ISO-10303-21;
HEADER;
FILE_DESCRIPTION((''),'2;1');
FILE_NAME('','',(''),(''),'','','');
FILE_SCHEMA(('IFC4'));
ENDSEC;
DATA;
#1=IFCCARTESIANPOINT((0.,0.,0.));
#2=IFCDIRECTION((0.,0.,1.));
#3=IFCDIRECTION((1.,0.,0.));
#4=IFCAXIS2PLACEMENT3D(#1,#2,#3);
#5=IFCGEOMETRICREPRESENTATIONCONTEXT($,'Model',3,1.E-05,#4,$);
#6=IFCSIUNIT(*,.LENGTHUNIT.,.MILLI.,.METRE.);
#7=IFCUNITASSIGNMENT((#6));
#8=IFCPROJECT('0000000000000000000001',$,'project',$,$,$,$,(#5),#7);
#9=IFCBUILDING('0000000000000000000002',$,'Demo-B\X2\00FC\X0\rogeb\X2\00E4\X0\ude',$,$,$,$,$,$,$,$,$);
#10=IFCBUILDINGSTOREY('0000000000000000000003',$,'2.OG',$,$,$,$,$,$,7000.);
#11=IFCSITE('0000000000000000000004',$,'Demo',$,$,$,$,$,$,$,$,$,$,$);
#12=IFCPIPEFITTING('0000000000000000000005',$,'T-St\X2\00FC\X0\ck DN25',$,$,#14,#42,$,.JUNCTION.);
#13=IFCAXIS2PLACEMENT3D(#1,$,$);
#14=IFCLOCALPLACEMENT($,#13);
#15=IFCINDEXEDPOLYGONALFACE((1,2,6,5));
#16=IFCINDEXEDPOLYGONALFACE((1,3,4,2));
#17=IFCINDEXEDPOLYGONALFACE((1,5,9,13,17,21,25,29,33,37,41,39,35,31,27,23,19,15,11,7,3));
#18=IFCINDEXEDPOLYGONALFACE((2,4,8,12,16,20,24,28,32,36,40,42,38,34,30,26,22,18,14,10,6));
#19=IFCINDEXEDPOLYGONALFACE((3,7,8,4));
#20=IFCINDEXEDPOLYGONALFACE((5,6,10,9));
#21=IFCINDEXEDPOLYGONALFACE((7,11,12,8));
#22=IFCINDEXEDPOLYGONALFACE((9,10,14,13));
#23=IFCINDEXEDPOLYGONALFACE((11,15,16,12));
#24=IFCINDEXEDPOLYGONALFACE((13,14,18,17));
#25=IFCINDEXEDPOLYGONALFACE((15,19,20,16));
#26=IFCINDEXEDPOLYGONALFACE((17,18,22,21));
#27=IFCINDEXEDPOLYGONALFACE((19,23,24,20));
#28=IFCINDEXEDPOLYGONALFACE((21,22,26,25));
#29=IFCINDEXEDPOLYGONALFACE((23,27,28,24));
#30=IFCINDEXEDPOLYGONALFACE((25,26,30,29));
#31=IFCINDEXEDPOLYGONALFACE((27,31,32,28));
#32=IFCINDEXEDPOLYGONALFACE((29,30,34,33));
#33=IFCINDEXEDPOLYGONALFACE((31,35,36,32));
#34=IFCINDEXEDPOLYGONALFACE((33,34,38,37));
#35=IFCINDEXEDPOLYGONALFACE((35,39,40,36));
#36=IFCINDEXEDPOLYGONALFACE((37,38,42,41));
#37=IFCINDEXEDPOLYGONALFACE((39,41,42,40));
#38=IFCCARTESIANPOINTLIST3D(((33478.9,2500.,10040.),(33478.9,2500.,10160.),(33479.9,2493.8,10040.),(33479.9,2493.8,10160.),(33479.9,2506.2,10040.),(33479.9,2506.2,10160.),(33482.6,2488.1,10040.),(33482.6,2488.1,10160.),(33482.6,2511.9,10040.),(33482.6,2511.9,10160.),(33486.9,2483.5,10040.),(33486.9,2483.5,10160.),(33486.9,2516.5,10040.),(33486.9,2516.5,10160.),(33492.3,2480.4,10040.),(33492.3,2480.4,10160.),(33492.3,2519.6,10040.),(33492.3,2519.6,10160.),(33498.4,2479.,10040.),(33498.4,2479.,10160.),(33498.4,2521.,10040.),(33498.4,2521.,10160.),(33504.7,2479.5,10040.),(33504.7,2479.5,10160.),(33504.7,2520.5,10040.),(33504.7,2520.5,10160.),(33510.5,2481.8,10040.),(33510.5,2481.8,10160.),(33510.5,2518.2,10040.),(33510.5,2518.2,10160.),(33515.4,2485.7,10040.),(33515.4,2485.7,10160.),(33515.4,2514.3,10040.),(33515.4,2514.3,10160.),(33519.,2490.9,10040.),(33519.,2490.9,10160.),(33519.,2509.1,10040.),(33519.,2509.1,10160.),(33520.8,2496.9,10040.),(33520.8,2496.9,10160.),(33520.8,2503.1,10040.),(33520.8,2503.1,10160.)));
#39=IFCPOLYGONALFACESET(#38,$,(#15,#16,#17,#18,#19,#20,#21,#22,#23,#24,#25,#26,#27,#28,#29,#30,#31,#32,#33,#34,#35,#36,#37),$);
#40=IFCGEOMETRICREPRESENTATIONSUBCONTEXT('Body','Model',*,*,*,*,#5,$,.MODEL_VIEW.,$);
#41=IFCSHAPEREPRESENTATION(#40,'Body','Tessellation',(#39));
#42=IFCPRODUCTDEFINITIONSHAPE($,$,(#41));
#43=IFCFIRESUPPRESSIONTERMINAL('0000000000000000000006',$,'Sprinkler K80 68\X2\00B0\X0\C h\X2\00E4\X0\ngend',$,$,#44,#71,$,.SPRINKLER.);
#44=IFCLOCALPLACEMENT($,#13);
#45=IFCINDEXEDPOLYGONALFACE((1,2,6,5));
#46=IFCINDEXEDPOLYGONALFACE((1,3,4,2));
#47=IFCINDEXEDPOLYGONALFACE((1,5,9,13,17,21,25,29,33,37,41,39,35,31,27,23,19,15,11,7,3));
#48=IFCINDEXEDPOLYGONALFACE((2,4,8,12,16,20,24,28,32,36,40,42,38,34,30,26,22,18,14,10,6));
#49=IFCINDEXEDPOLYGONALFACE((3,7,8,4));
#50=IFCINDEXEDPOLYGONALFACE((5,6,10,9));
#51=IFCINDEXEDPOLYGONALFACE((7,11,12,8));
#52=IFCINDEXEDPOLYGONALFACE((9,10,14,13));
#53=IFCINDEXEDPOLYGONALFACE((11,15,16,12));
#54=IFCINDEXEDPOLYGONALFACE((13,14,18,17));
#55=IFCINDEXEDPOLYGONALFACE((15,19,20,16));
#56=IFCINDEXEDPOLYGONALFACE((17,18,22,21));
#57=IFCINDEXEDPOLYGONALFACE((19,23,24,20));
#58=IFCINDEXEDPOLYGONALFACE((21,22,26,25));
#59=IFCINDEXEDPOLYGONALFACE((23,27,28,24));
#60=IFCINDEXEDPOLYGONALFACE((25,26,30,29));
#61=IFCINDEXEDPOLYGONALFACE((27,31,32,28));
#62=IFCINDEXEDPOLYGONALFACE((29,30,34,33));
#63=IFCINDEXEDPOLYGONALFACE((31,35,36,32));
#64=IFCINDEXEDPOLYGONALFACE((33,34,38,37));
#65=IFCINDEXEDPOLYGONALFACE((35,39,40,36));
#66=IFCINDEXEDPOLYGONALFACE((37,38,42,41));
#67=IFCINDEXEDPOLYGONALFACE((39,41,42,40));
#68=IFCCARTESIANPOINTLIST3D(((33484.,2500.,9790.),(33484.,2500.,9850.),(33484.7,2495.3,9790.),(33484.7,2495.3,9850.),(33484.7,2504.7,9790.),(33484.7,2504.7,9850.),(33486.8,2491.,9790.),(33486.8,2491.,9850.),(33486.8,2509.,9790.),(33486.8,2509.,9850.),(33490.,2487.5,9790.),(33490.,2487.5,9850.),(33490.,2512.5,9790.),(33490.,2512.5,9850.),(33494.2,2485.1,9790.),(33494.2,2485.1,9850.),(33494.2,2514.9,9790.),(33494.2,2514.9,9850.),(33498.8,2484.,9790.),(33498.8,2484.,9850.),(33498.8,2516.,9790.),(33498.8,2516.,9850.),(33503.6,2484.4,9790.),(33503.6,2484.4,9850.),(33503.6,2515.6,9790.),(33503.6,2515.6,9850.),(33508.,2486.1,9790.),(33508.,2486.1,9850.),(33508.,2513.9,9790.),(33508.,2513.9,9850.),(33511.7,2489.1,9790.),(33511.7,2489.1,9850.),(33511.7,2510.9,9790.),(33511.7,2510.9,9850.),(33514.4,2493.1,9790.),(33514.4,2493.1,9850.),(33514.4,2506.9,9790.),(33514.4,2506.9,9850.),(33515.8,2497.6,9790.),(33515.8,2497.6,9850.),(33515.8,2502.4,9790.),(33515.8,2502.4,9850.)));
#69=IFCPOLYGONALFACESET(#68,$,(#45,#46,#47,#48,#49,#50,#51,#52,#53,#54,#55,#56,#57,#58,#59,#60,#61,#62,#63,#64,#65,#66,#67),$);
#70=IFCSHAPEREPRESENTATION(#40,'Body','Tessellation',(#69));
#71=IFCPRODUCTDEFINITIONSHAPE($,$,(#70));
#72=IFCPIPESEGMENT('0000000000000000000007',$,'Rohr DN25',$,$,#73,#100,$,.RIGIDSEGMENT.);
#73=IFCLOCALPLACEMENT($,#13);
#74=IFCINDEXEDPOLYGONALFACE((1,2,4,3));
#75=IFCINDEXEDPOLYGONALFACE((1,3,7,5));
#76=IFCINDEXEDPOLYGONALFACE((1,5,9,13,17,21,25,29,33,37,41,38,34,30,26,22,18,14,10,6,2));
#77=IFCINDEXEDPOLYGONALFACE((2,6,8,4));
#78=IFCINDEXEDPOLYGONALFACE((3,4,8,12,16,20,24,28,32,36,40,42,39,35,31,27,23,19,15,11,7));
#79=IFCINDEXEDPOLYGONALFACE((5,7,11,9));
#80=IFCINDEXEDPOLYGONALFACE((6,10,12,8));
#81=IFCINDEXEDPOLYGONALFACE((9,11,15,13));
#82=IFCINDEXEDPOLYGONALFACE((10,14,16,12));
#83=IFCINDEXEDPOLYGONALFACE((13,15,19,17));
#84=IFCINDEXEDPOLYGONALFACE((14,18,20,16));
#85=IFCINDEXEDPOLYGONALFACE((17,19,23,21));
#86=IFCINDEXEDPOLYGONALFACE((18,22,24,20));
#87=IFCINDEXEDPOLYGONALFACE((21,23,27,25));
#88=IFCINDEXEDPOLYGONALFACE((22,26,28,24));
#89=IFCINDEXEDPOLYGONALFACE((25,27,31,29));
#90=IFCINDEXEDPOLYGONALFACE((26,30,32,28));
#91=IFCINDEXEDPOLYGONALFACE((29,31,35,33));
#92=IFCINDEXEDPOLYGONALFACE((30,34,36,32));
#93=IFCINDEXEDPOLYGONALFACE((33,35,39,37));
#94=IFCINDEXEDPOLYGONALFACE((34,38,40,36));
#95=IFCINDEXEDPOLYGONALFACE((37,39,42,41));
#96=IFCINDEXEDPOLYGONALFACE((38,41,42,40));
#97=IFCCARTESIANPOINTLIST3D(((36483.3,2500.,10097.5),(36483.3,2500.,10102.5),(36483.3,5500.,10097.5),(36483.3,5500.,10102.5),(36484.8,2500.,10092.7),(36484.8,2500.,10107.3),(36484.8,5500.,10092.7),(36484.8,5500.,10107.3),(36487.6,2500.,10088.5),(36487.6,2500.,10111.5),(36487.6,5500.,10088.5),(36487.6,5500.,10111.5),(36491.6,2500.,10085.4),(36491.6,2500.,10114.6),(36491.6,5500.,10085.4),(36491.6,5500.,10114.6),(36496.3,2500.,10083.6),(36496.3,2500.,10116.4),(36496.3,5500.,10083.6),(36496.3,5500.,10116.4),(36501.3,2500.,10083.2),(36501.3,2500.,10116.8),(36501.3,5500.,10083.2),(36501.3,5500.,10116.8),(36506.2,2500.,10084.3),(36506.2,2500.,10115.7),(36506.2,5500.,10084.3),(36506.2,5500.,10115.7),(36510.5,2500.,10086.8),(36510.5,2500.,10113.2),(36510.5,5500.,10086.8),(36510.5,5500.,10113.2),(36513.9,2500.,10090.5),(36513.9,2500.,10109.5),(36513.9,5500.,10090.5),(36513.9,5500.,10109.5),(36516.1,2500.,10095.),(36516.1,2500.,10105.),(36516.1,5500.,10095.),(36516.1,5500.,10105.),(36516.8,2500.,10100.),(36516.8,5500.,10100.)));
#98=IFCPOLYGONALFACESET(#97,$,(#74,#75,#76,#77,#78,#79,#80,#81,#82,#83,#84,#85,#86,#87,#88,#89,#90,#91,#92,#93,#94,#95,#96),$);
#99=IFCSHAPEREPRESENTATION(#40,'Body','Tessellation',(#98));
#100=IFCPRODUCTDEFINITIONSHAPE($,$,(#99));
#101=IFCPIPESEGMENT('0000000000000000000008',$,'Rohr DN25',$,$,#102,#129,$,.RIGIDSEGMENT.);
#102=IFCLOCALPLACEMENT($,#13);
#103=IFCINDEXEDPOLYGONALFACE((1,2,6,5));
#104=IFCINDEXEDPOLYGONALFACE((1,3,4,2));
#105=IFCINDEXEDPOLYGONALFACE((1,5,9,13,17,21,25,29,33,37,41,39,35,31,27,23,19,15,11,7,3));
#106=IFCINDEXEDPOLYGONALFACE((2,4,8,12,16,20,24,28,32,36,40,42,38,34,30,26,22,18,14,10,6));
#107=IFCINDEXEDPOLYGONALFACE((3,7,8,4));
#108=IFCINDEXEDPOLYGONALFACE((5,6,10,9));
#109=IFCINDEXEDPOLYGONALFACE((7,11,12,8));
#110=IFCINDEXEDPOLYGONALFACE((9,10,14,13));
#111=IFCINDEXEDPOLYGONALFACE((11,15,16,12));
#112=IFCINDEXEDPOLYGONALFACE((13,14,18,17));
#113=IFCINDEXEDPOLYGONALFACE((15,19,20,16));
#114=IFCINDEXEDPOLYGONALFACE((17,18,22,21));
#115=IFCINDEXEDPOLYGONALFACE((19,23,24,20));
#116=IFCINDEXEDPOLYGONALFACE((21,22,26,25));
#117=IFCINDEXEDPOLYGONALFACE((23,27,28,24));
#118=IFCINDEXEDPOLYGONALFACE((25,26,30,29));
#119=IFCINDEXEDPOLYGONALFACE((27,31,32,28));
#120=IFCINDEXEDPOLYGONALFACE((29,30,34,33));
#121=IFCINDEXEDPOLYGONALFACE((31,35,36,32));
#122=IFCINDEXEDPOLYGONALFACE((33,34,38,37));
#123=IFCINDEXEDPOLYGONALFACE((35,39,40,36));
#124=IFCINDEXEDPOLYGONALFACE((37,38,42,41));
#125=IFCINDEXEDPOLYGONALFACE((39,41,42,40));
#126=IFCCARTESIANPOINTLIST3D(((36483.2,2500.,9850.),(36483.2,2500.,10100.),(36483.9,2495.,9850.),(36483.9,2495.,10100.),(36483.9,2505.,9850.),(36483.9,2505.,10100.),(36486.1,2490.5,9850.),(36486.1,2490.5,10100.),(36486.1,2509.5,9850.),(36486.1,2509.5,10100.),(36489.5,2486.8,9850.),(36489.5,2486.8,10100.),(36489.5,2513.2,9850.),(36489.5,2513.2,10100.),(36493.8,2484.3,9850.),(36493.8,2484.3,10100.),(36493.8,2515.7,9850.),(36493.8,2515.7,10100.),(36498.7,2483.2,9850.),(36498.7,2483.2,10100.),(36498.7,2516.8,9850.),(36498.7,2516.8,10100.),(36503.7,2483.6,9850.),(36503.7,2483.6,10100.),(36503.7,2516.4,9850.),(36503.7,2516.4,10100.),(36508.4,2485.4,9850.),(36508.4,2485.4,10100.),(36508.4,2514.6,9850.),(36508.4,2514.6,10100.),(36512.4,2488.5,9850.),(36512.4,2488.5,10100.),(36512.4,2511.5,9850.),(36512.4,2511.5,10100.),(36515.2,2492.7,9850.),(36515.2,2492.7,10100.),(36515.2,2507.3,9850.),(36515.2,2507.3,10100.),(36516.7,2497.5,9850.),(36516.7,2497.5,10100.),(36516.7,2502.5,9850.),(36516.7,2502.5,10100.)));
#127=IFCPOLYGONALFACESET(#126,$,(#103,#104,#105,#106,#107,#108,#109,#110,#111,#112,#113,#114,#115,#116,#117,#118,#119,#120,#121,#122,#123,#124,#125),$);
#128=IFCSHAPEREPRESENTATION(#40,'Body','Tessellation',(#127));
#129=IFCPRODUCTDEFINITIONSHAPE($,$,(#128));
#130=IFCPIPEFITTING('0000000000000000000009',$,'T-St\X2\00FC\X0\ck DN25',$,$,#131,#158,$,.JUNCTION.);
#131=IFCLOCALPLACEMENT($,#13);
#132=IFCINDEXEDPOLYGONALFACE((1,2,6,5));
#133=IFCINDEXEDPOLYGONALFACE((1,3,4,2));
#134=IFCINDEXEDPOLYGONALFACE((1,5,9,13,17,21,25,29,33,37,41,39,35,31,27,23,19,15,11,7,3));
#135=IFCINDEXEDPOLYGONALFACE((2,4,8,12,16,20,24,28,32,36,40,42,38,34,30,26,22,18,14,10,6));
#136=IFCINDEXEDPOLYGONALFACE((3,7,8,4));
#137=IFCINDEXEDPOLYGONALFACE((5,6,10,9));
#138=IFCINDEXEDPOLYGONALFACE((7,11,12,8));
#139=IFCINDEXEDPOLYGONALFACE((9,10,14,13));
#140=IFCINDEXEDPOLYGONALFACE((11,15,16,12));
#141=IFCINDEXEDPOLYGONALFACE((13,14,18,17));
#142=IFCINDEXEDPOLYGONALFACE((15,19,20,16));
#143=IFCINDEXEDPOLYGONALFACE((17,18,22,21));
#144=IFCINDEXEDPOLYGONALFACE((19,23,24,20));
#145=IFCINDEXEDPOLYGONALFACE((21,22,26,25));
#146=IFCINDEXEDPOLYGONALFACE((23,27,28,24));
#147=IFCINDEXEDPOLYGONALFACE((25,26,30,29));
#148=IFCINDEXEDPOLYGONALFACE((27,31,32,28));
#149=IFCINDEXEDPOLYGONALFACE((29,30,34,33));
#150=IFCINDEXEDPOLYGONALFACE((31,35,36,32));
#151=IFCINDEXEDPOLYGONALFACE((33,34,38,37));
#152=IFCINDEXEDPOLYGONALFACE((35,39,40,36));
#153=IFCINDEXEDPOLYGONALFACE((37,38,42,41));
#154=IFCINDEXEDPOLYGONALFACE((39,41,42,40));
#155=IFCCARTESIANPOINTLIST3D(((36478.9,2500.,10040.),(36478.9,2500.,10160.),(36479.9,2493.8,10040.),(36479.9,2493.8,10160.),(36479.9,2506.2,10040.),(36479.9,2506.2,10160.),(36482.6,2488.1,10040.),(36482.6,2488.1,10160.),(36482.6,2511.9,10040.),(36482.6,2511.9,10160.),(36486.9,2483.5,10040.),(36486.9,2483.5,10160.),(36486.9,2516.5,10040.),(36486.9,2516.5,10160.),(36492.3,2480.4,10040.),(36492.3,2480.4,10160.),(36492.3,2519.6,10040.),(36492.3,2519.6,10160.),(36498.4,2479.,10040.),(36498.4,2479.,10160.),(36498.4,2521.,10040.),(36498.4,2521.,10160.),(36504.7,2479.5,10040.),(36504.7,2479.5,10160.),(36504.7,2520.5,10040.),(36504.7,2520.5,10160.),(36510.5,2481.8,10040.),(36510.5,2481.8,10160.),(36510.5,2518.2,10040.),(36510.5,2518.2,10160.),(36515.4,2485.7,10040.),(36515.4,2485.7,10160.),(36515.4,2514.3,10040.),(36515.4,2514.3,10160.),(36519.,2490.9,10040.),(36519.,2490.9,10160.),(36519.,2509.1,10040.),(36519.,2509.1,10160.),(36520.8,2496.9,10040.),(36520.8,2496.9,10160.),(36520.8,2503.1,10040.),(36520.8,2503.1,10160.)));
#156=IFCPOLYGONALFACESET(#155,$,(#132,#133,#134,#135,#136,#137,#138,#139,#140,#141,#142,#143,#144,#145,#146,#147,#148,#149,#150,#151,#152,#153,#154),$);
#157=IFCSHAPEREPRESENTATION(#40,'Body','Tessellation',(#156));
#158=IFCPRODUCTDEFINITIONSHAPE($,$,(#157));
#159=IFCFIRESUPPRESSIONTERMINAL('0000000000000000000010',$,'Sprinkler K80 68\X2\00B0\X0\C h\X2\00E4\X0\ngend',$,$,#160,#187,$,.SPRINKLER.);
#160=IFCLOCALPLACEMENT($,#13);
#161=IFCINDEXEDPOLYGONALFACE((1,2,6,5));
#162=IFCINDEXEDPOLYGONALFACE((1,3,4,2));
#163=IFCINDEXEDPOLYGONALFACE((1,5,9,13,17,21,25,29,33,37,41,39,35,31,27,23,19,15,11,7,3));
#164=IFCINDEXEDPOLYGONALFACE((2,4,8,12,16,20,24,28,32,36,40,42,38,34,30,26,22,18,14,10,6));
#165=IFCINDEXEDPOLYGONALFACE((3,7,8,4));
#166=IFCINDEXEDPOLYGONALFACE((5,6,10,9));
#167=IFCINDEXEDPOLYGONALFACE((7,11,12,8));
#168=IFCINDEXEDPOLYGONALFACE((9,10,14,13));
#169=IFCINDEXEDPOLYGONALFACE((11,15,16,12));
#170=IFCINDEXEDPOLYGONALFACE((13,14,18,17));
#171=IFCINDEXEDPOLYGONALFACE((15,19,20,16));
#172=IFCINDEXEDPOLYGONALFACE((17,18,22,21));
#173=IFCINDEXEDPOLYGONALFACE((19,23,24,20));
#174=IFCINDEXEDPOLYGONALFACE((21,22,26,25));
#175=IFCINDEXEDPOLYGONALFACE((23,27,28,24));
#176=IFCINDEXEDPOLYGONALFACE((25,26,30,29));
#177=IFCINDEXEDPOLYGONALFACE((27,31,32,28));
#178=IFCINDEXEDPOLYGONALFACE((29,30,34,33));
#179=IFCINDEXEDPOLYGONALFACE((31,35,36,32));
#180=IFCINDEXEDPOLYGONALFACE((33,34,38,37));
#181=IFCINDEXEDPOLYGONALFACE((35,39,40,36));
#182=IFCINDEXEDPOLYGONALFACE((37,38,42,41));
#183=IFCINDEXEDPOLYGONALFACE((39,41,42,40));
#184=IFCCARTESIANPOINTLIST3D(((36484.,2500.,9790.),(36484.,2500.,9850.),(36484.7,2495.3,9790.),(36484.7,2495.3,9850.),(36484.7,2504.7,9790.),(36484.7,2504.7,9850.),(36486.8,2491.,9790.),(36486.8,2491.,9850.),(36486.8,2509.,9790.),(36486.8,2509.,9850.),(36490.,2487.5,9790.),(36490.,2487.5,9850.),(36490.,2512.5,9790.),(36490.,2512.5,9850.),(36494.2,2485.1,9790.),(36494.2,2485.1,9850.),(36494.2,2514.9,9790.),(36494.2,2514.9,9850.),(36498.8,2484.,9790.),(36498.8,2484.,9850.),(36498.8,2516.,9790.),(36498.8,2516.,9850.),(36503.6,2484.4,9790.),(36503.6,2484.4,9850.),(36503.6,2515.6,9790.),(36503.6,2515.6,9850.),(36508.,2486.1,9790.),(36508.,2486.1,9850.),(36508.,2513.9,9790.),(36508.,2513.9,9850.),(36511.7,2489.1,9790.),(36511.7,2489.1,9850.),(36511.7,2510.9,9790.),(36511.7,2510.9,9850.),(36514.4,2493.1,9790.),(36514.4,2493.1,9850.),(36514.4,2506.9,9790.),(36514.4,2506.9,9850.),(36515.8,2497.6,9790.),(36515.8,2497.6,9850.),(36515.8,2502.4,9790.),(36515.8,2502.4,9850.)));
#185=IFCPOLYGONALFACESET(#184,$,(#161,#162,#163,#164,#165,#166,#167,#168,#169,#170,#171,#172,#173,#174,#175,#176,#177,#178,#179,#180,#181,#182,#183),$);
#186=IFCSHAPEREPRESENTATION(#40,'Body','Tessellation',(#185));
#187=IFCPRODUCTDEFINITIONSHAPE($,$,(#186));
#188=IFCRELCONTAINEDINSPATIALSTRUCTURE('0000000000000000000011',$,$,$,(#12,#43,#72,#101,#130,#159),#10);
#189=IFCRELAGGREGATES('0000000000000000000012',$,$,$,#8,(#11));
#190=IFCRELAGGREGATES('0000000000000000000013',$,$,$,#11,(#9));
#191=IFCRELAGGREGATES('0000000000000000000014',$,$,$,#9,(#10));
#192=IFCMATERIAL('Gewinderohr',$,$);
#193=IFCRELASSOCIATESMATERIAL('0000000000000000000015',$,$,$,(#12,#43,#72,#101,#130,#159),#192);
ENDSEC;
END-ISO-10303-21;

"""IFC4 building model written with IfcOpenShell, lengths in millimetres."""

from ifc_helpers import new_model, si_unit, frame, origin_with_axes, place, context, subcontext, project, spatial, circle, extrude, material, element, save


model = new_model("IFC4")

# Units and contexts
model_context = context("Model", 3, precision=1e-05, world=origin_with_axes())
body_context = subcontext(model_context, "Body", "Model", "MODEL_VIEW")
ifc_project = project(units=[si_unit("LENGTHUNIT", "METRE", prefix="MILLI")], contexts=[model_context])

# Site, building, storey
site = spatial("IfcSite", under=ifc_project, Name="Demo")
building = spatial("IfcBuilding", under=site, Name="Demo-Bürogebäude")
storey = spatial("IfcBuildingStorey", under=building, Name="2.OG", Elevation=7000.0)

# Shared definitions
ifc_material_1 = material(Name="Gewinderohr")

# Pipe fitting
pipe_fitting_1_placement = place(None, frame((33500.0, 2500.0, 10160.0), z_axis=(0.0, 0.0, -1.0), x_axis=(-1.0, 0.0, 0.0)))
element("IfcPipeFitting", 1, at=pipe_fitting_1_placement, inside=storey, material=ifc_material_1, Name="T-Stück DN25", PredefinedType="JUNCTION", context=body_context, shape_type="SweptSolid", body=[
    extrude(circle(Radius=21.1), origin_with_axes(), (0.0, 0.0, 1.0), 120.0),
])

# Fire suppression terminal
fire_suppression_terminal_1_placement = place(None, frame((33500.0, 2500.0, 9850.0), z_axis=(0.0, 0.0, -1.0), x_axis=(-1.0, 0.0, 0.0)))
element("IfcFireSuppressionTerminal", 2, at=fire_suppression_terminal_1_placement, inside=storey, material=ifc_material_1, Name="Sprinkler K80 68°C hängend", PredefinedType="SPRINKLER", context=body_context, shape_type="SweptSolid", body=[
    extrude(circle(Radius=16.0), origin_with_axes(), (0.0, 0.0, 1.0), 60.0),
])

# Pipe segments
pipe_segment_1_placement = place(None, frame((36500.0, 5500.0, 10100.0), z_axis=(0.0, -1.0, 0.0), x_axis=(1.0, 0.0, 0.0)))
element("IfcPipeSegment", 3, at=pipe_segment_1_placement, inside=storey, material=ifc_material_1, Name="Rohr DN25", PredefinedType="RIGIDSEGMENT", context=body_context, shape_type="SweptSolid", body=[
    extrude(circle(Radius=16.9), origin_with_axes(), (0.0, 0.0, 1.0), 3000.0),
])
pipe_segment_2_placement = place(None, frame((36500.0, 2500.0, 10100.0), z_axis=(0.0, 0.0, -1.0), x_axis=(-1.0, 0.0, 0.0)))
element("IfcPipeSegment", 4, at=pipe_segment_2_placement, inside=storey, material=ifc_material_1, Name="Rohr DN25", PredefinedType="RIGIDSEGMENT", context=body_context, shape_type="SweptSolid", body=[
    extrude(circle(Radius=16.9), origin_with_axes(), (0.0, 0.0, 1.0), 250.0),
])

# Pipe fitting
pipe_fitting_2_placement = place(None, frame((36500.0, 2500.0, 10160.0), z_axis=(0.0, 0.0, -1.0), x_axis=(-1.0, 0.0, 0.0)))
element("IfcPipeFitting", 5, at=pipe_fitting_2_placement, inside=storey, material=ifc_material_1, Name="T-Stück DN25", PredefinedType="JUNCTION", context=body_context, shape_type="SweptSolid", body=[
    extrude(circle(Radius=21.1), origin_with_axes(), (0.0, 0.0, 1.0), 120.0),
])

# Fire suppression terminal
fire_suppression_terminal_2_placement = place(None, frame((36500.0, 2500.0, 9850.0), z_axis=(0.0, 0.0, -1.0), x_axis=(-1.0, 0.0, 0.0)))
element("IfcFireSuppressionTerminal", 6, at=fire_suppression_terminal_2_placement, inside=storey, material=ifc_material_1, Name="Sprinkler K80 68°C hängend", PredefinedType="SPRINKLER", context=body_context, shape_type="SweptSolid", body=[
    extrude(circle(Radius=16.0), origin_with_axes(), (0.0, 0.0, 1.0), 60.0),
])

save(model, "model.ifc")
